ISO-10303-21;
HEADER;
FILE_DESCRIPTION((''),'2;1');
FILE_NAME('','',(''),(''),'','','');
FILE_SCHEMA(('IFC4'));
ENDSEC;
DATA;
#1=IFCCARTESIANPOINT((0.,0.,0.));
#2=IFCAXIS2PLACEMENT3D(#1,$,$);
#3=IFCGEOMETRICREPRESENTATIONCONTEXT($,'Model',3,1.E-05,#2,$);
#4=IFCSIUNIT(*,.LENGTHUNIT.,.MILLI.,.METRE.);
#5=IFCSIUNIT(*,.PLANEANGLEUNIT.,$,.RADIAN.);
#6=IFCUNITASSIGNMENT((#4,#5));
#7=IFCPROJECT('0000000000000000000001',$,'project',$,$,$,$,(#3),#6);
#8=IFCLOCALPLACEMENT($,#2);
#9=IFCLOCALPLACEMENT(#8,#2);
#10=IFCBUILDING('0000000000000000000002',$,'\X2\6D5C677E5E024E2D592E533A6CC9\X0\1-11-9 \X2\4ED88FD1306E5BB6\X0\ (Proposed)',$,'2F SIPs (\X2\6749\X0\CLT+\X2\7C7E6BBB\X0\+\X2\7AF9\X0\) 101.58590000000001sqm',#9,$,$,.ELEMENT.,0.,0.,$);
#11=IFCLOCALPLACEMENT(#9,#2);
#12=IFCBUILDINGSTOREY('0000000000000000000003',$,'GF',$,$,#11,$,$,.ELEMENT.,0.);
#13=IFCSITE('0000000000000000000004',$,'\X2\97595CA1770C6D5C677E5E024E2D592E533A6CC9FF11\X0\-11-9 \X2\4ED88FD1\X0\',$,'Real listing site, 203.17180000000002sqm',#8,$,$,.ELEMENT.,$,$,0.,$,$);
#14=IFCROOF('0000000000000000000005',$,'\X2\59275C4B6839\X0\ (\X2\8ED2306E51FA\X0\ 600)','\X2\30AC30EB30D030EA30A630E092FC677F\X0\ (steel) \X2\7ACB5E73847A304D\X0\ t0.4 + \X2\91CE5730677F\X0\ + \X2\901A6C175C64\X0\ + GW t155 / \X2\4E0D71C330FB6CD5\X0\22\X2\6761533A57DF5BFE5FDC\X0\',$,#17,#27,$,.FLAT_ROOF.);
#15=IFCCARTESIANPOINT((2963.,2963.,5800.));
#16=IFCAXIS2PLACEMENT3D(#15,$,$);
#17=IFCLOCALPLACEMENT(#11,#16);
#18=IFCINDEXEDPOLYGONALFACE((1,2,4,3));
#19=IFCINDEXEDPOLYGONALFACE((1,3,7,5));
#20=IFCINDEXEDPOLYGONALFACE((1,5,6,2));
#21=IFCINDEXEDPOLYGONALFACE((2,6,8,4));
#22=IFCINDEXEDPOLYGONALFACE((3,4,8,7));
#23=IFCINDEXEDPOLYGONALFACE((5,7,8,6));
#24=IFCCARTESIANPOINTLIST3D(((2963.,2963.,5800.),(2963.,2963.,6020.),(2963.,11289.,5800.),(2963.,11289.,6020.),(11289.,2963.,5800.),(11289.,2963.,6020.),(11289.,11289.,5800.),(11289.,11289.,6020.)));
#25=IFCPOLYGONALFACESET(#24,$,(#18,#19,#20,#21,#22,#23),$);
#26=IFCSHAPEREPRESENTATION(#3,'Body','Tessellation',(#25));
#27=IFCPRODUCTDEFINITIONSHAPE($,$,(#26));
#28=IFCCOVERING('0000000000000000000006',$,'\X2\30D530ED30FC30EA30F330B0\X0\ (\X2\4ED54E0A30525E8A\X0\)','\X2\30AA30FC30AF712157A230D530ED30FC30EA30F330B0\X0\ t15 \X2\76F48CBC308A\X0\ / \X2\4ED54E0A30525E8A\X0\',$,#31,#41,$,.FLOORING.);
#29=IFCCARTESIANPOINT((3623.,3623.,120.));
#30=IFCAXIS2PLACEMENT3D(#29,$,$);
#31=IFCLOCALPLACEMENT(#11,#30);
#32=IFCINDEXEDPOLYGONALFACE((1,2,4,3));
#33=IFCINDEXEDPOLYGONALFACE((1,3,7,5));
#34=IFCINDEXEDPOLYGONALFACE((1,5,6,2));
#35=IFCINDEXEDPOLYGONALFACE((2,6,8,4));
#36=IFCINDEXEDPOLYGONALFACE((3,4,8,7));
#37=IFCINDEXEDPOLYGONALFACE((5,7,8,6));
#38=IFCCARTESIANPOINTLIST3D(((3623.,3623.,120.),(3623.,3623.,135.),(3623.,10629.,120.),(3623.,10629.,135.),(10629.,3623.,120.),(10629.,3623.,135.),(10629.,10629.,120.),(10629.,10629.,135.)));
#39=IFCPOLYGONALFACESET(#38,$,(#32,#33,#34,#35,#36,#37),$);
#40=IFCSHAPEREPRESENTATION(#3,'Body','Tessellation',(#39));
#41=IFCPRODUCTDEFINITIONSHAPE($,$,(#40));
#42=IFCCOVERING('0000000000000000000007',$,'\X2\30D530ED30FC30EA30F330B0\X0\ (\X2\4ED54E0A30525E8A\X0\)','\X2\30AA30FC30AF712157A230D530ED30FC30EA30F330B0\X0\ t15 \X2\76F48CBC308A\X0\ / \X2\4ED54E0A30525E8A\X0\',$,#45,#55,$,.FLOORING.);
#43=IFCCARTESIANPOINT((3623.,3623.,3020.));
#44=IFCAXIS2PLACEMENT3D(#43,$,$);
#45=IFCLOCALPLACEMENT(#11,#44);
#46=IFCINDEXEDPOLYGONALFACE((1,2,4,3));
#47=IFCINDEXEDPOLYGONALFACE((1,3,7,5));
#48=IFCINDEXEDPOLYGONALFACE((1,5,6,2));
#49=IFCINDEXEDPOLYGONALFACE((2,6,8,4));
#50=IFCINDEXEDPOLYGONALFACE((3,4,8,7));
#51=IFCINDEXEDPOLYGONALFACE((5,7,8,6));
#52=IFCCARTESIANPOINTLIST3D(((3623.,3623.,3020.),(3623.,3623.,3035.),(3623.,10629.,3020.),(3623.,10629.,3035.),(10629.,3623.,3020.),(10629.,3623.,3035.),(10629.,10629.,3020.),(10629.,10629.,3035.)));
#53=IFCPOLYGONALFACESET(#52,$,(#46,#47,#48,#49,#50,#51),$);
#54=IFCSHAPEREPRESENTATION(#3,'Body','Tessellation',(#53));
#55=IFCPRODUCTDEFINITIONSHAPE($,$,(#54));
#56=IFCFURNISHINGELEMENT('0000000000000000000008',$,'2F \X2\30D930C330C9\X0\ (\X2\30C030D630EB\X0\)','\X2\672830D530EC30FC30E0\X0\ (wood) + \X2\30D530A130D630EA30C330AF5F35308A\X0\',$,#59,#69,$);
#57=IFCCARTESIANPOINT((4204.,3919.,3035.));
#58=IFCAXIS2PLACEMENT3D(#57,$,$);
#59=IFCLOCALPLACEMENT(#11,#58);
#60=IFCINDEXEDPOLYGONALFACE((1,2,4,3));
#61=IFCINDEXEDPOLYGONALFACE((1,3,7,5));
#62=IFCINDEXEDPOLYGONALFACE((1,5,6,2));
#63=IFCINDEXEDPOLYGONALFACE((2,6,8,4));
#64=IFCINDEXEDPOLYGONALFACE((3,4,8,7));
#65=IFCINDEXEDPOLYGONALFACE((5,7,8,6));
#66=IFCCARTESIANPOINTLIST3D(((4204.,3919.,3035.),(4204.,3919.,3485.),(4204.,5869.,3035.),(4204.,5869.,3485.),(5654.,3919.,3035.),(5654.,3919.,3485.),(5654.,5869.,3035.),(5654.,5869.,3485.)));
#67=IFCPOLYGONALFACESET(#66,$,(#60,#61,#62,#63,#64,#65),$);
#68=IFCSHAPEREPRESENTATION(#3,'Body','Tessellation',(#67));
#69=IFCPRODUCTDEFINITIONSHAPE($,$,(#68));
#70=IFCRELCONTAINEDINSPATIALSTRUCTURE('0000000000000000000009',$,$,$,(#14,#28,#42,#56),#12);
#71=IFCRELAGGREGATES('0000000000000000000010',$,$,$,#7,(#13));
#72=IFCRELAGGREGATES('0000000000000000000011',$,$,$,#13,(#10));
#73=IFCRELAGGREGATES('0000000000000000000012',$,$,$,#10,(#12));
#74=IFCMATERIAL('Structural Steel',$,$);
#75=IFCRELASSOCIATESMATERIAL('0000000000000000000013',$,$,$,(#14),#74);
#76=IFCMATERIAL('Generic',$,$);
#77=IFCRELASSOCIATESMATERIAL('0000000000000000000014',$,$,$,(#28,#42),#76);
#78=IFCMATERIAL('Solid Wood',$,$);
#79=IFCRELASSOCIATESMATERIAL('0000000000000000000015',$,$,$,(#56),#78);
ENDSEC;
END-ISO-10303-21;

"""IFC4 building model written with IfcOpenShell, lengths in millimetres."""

from ifc_helpers import new_model, si_unit, frame, frame_2d, origin, place, context, project, spatial, rectangle, extrude, material, element, save


model = new_model("IFC4")

# Units and contexts
model_context = context("Model", 3, precision=1e-05, world=origin())
ifc_project = project(units=[si_unit("LENGTHUNIT", "METRE", prefix="MILLI"), si_unit("PLANEANGLEUNIT", "RADIAN")], contexts=[model_context])

# Site, building, storey
site_placement = place(None, origin())
site = spatial("IfcSite", under=ifc_project, at=site_placement, Name="静岡県浜松市中央区泉１-11-9 付近", ObjectType="Real listing site, 203.17180000000002sqm", CompositionType="ELEMENT", RefElevation=0.0)
building_placement = place(site_placement, origin())
building = spatial("IfcBuilding", under=site, at=building_placement, Name="浜松市中央区泉1-11-9 付近の家 (Proposed)", ObjectType="2F SIPs (杉CLT+籾殻+竹) 101.58590000000001sqm", CompositionType="ELEMENT", ElevationOfRefHeight=0.0, ElevationOfTerrain=0.0)
storey_placement = place(building_placement, origin())
storey = spatial("IfcBuildingStorey", under=building, at=storey_placement, Name="GF", CompositionType="ELEMENT", Elevation=0.0)

# Shared definitions
ifc_material_1 = material(Name="Solid Wood")

# Roof
ifc_material_2 = material(Name="Structural Steel")
roof_placement = place(storey_placement, frame((2963.0, 2963.0, 5800.0)))
element("IfcRoof", 1, at=roof_placement, inside=storey, material=ifc_material_2, Name="大屋根 (軒の出 600)", Description="ガルバリウム鋼板 (steel) 立平葺き t0.4 + 野地板 + 通気層 + GW t155 / 不燃・法22条区域対応", PredefinedType="FLAT_ROOF", context=model_context, shape_type="SweptSolid", body=[
    extrude(rectangle(XDim=8326.0, YDim=8326.0, at=frame_2d((4163.0, 4163.0))), frame((2963.0, 2963.0, 5800.0)), (0.0, 0.0, 1.0), 220.0),
])

# Coverings
ifc_material_3 = material(Name="Generic")
covering_1_placement = place(storey_placement, frame((3623.0, 3623.0, 120.0)))
element("IfcCovering", 2, at=covering_1_placement, inside=storey, material=ifc_material_3, Name="フローリング (仕上げ床)", Description="オーク無垢フローリング t15 直貼り / 仕上げ床", PredefinedType="FLOORING", context=model_context, shape_type="SweptSolid", body=[
    extrude(rectangle(XDim=7006.0, YDim=7006.0, at=frame_2d((3503.0, 3503.0))), frame((3623.0, 3623.0, 120.0)), (0.0, 0.0, 1.0), 15.0),
])
covering_2_placement = place(storey_placement, frame((3623.0, 3623.0, 3020.0)))
element("IfcCovering", 3, at=covering_2_placement, inside=storey, material=ifc_material_3, Name="フローリング (仕上げ床)", Description="オーク無垢フローリング t15 直貼り / 仕上げ床", PredefinedType="FLOORING", context=model_context, shape_type="SweptSolid", body=[
    extrude(rectangle(XDim=7006.0, YDim=7006.0, at=frame_2d((3503.0, 3503.0))), frame((3623.0, 3623.0, 3020.0)), (0.0, 0.0, 1.0), 15.0),
])

# Furnishing element
furnishing_placement = place(storey_placement, frame((4204.0, 3919.0, 3035.0)))
element("IfcFurnishingElement", 4, at=furnishing_placement, inside=storey, material=ifc_material_1, Name="2F ベッド (ダブル)", Description="木フレーム (wood) + ファブリック張り", context=model_context, shape_type="SweptSolid", body=[
    extrude(rectangle(XDim=1450.0, YDim=1950.0, at=frame_2d((725.0, 975.0))), frame((4204.0, 3919.0, 3035.0)), (0.0, 0.0, 1.0), 450.0),
])

save(model, "model.ifc")
